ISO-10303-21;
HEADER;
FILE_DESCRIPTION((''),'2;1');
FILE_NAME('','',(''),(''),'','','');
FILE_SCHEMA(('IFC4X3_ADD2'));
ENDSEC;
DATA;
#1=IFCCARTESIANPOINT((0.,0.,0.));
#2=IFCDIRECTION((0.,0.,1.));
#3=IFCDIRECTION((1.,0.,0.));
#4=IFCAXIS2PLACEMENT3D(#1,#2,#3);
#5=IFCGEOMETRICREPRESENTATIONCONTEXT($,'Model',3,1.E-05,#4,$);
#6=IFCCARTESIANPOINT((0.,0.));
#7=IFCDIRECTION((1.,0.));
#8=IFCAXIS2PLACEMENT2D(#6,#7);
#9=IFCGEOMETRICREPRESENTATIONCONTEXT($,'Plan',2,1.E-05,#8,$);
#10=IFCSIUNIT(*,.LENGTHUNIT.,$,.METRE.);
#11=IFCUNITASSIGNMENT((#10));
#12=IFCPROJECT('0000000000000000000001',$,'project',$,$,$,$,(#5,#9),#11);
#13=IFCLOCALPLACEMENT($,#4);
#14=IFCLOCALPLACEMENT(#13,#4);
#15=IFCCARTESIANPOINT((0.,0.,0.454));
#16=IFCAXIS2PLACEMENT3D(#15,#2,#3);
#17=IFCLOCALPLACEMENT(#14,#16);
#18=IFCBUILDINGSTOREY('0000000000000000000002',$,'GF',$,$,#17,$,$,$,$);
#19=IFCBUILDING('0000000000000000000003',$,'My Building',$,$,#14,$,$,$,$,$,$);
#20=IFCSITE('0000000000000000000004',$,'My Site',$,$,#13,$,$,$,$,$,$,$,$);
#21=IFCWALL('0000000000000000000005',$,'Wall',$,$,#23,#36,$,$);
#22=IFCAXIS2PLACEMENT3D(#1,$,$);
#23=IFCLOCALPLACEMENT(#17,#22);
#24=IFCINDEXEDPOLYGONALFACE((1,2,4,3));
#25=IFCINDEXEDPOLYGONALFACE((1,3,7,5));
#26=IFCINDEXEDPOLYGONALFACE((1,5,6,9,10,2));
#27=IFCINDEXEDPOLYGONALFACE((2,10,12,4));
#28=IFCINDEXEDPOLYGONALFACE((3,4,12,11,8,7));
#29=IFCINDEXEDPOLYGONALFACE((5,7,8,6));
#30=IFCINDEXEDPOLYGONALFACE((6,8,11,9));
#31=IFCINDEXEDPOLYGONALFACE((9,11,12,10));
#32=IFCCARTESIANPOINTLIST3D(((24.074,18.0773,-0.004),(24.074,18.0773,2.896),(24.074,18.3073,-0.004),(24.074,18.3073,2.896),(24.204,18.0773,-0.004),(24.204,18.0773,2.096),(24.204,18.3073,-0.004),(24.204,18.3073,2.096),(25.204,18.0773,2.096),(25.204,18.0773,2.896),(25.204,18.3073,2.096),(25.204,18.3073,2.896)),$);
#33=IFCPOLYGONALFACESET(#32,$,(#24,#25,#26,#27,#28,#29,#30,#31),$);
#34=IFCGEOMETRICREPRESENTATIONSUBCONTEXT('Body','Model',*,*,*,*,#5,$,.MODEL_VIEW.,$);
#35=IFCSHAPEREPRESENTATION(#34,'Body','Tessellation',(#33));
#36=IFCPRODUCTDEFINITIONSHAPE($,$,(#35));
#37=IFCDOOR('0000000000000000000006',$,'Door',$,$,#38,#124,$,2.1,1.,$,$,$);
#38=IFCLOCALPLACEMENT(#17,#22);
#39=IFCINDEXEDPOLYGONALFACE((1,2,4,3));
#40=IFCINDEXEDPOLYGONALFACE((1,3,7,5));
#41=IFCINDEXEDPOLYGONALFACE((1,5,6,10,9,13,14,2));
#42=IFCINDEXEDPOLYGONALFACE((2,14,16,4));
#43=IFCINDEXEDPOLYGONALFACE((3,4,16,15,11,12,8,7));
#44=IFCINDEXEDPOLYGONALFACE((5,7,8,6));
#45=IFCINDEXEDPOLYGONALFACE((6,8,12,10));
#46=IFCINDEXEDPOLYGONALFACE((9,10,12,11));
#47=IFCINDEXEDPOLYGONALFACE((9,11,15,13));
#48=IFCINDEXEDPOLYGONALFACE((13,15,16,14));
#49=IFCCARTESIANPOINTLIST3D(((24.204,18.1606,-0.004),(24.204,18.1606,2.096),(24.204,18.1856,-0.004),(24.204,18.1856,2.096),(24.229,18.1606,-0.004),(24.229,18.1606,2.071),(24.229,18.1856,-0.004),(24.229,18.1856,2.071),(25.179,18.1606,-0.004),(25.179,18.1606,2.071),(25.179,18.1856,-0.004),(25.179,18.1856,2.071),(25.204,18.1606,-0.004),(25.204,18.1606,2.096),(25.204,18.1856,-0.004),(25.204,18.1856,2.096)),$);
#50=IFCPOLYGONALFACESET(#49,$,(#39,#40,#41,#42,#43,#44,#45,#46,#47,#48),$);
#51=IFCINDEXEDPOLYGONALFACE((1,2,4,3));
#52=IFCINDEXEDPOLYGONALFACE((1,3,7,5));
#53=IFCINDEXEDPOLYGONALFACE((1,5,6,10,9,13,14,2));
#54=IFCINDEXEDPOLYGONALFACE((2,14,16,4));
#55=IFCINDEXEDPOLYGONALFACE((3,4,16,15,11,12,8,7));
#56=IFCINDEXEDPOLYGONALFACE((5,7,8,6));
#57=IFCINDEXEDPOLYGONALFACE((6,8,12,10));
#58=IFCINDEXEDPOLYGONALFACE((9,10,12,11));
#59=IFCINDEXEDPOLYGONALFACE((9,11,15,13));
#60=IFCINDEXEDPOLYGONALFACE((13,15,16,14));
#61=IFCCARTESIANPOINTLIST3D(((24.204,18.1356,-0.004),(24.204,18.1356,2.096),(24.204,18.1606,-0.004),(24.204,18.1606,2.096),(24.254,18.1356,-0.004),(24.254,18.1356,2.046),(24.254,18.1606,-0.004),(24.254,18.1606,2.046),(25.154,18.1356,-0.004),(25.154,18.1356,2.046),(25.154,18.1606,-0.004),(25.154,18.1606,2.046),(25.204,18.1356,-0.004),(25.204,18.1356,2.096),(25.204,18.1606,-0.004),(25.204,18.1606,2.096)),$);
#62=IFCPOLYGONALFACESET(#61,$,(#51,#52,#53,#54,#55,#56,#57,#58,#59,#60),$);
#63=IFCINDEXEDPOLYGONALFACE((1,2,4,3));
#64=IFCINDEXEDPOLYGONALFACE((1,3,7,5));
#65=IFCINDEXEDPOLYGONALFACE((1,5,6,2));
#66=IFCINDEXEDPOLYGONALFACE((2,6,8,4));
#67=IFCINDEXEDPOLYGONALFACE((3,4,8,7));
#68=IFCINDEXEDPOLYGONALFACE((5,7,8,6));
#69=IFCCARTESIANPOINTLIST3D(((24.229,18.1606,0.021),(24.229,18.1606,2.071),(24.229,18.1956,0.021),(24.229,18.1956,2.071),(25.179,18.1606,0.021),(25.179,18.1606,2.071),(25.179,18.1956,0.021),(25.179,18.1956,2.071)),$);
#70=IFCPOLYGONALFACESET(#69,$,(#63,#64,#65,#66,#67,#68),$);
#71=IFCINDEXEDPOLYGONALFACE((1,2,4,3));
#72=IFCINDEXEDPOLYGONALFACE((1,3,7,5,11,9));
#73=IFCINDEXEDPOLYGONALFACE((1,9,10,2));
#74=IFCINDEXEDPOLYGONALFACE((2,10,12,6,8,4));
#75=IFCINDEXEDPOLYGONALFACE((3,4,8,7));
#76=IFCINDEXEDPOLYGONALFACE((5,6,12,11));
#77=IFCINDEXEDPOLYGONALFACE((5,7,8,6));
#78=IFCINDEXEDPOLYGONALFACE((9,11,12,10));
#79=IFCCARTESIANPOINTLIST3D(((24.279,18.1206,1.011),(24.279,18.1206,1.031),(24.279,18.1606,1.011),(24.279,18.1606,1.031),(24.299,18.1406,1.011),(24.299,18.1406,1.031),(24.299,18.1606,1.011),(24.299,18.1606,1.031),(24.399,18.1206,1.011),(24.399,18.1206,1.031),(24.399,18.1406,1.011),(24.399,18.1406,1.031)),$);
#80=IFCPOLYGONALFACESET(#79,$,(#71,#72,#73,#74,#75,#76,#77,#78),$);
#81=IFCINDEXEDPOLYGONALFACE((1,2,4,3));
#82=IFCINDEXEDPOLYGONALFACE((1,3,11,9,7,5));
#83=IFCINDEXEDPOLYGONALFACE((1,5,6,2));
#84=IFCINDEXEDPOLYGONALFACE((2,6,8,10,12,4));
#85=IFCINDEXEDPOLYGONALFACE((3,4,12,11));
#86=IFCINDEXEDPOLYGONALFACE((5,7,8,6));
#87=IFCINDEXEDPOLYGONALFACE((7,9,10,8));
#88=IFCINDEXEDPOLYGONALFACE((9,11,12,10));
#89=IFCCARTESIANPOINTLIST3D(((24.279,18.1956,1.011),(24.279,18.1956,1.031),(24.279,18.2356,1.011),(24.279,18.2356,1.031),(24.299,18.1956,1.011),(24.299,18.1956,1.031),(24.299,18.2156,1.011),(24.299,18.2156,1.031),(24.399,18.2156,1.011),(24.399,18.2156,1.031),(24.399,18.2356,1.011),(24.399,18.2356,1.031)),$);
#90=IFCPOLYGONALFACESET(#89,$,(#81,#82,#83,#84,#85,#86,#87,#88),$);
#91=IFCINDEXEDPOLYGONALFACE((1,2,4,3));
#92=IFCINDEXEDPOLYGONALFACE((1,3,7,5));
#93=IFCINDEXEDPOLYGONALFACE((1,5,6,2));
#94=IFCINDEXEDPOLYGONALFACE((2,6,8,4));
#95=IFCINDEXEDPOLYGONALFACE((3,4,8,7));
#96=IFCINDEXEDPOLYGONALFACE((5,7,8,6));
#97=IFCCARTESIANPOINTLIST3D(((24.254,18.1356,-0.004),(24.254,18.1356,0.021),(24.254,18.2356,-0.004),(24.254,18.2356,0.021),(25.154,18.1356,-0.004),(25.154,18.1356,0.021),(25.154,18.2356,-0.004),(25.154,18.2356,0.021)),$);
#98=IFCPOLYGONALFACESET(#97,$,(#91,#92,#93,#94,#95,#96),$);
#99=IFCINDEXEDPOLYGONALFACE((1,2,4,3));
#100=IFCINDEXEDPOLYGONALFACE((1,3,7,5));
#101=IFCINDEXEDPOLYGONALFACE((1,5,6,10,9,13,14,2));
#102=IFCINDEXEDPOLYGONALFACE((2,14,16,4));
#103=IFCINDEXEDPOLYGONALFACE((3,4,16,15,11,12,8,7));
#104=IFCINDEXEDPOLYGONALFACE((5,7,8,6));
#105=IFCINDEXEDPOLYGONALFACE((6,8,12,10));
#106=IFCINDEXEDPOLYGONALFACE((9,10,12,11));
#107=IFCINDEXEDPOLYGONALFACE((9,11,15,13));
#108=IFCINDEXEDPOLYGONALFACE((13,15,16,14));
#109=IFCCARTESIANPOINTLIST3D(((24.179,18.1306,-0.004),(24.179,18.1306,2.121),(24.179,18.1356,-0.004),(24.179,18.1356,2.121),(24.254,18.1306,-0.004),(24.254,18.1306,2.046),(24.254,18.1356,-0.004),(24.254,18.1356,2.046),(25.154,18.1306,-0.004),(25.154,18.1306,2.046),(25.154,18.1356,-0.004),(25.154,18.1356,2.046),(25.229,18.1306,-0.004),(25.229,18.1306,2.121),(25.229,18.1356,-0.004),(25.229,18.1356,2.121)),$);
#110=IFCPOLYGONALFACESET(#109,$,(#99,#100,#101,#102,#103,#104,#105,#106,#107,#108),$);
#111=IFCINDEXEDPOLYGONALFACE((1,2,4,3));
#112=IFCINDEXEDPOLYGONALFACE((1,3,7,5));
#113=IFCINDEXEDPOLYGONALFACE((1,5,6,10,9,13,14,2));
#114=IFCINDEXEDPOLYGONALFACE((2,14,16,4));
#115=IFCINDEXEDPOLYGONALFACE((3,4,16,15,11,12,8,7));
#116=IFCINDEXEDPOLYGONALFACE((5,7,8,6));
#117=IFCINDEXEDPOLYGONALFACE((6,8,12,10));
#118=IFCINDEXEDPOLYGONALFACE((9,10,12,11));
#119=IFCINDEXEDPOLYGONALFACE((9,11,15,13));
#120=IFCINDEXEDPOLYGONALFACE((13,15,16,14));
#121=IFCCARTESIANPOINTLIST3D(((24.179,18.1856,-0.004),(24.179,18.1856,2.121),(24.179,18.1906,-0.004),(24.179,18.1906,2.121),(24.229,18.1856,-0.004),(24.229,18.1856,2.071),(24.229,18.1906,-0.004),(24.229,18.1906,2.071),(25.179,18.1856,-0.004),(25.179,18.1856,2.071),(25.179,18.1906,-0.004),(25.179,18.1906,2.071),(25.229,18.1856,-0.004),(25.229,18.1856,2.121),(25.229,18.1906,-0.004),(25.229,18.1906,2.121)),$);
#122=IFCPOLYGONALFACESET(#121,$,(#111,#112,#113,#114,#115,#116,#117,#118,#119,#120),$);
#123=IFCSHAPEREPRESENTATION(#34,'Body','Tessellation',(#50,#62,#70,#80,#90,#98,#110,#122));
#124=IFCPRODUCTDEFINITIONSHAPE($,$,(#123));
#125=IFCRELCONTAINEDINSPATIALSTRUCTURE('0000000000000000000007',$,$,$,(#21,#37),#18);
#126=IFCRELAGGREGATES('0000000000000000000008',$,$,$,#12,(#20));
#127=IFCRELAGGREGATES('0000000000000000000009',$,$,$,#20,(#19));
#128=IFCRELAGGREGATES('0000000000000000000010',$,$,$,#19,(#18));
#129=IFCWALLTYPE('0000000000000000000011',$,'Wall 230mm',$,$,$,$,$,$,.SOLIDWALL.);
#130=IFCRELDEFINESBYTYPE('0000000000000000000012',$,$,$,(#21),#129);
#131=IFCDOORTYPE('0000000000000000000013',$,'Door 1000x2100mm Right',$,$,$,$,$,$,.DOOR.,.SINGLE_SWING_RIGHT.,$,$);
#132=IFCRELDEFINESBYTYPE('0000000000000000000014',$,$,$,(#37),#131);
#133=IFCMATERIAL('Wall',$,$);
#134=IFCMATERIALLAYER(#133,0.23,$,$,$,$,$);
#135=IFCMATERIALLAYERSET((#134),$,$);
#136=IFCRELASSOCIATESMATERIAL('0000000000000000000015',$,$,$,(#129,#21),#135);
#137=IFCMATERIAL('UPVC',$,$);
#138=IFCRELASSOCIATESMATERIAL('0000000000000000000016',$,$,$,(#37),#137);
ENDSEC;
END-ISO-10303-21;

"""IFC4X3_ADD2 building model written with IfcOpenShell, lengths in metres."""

from ifc_helpers import new_model, entity, si_unit, frame, origin_with_axes, origin_2d_with_axis, place, context, subcontext, project, spatial, line, indexed_curve, outline, extrude, shape, source, transform, mapped, material, layer, layer_set, layer_usage, type_object, type_shapes, element, fill, save


model = new_model("IFC4X3_ADD2")

# Units and contexts
model_context = context("Model", 3, precision=1e-05, world=origin_with_axes())
plan_context = context("Plan", 2, precision=1e-05, world=origin_2d_with_axis())
body_context_1 = subcontext(model_context, "Body", "Model", "MODEL_VIEW")
body_context_2 = subcontext(plan_context, "Body", "Plan", "PLAN_VIEW")
ifc_project = project(units=[si_unit("LENGTHUNIT", "METRE")], contexts=[model_context, plan_context])

# Site, building, storey
site_placement = place(None, origin_with_axes())
site = spatial("IfcSite", under=ifc_project, at=site_placement, Name="My Site")
building_placement = place(site_placement, origin_with_axes())
building = spatial("IfcBuilding", under=site, at=building_placement, Name="My Building")
storey_placement = place(building_placement, frame((0.0, 0.0, 0.454), z_axis=(0.0, 0.0, 1.0), x_axis=(1.0, 0.0, 0.0)))
storey = spatial("IfcBuildingStorey", under=building, at=storey_placement, Name="GF")

# Shared definitions
ifc_material_1 = material(Name="Wall")
ifc_layer = layer(ifc_material_1, 0.23)
ifc_layer_set = layer_set([ifc_layer])
wall_type = type_object("IfcWallType", Name="Wall 230mm", PredefinedType="SOLIDWALL", material=ifc_layer_set)

# Shared definitions
shared_shape_1 = source(origin_with_axes(), body_context_1, "Body", "SweptSolid", [
    extrude(outline(indexed_curve([(0.0, 0.0), (1.0, 0.0), (1.0, 2.1), (0.0, 2.1)], segments=[line(1, 2, 3, 4, 1)])), frame((0.0, -0.6, 0.0), z_axis=(0.0, -1.0, 0.0), x_axis=(1.0, 0.0, 0.0)), (0.0, 0.0, -1.0), 1.2),
])
ifc_material_2 = material(Name="UPVC")
door_type_1 = type_object("IfcDoorType", Name="Door 1000x2100mm Right", OperationType="SINGLE_SWING_RIGHT", PredefinedType="DOOR")
shared_shape_2 = source(origin_with_axes(), body_context_1, "Body", "SweptSolid", [
    extrude(outline(indexed_curve([(0.0, 0.0), (0.0, 2.1), (1.0, 2.1), (1.0, 0.0), (0.975, 0.0), (0.975, 2.075), (0.025, 2.075), (0.025, 0.0)], segments=[line(1, 2, 3, 4, 5, 6, 7, 8, 1)])), frame((0.0, 0.025, 0.0), z_axis=(0.0, -1.0, 0.0), x_axis=(1.0, 0.0, 0.0)), (0.0, 0.0, -1.0), 0.025),
    extrude(outline(indexed_curve([(0.0, 0.0), (0.0, 2.1), (1.0, 2.1), (1.0, 0.0), (0.95, 0.0), (0.95, 2.05), (0.05, 2.05), (0.05, 0.0)], segments=[line(1, 2, 3, 4, 5, 6, 7, 8, 1)])), frame((0.0, 0.0, 0.0), z_axis=(0.0, -1.0, 0.0), x_axis=(1.0, 0.0, 0.0)), (0.0, 0.0, -1.0), 0.025),
    extrude(outline(indexed_curve([(0.0, 0.0), (0.95, 0.0), (0.95, 0.035), (0.0, 0.035)], segments=[line(1, 2, 3, 4, 1)])), frame((0.025, 0.025, 0.025), z_axis=(0.0, 0.0, 1.0), x_axis=(1.0, 0.0, 0.0)), (0.0, 0.0, 1.0), 2.05),
    extrude(outline(indexed_curve([(0.0, 0.0), (0.0, -0.04), (0.12, -0.04), (0.12, -0.02), (0.02, -0.02), (0.02, 0.0)], segments=[line(1, 2, 3, 4, 5, 6, 1)])), frame((0.075, 0.025, 1.015), z_axis=(0.0, 0.0, 1.0), x_axis=(1.0, 0.0, 0.0)), (0.0, 0.0, 1.0), 0.02),
    extrude(outline(indexed_curve([(0.0, 0.0), (0.0, 0.04), (0.12, 0.04), (0.12, 0.02), (0.02, 0.02), (0.02, 0.0)], segments=[line(1, 2, 3, 4, 5, 6, 1)])), frame((0.075, 0.06, 1.015), z_axis=(0.0, 0.0, 1.0), x_axis=(1.0, 0.0, 0.0)), (0.0, 0.0, 1.0), 0.02),
    extrude(outline(indexed_curve([(0.0, 0.0), (0.9, 0.0), (0.9, 0.1), (0.0, 0.1)], segments=[line(1, 2, 3, 4, 1)])), frame((0.05, 0.0, 0.0), z_axis=(0.0, 0.0, 1.0), x_axis=(1.0, 0.0, 0.0)), (0.0, 0.0, 1.0), 0.025),
    extrude(outline(indexed_curve([(0.0, 0.0), (0.0, 2.125), (1.05, 2.125), (1.05, 0.0), (0.975, 0.0), (0.975, 2.05), (0.075, 2.05), (0.075, 0.0)], segments=[line(1, 2, 3, 4, 5, 6, 7, 8, 1)])), frame((-0.025, -0.005, 0.0), z_axis=(0.0, -1.0, 0.0), x_axis=(1.0, 0.0, 0.0)), (0.0, 0.0, -1.0), 0.005),
    extrude(outline(indexed_curve([(0.0, 0.0), (0.0, 2.125), (1.05, 2.125), (1.05, 0.0), (1.0, 0.0), (1.0, 2.075), (0.05, 2.075), (0.05, 0.0)], segments=[line(1, 2, 3, 4, 5, 6, 7, 8, 1)])), frame((-0.025, 0.05, 0.0), z_axis=(0.0, -1.0, 0.0), x_axis=(1.0, 0.0, 0.0)), (0.0, 0.0, -1.0), 0.005),
])
shared_shape_3 = source(origin_with_axes(), body_context_2, "Body", "Curve2D", [
    entity("IfcIndexedPolyCurve", entity("IfcCartesianPointList2D", [[0.0, 0.0], [0.0, 0.05], [0.025, 0.05], [0.025, 0.025], [0.05, 0.025], [0.05, 0.0]]), [entity("IfcLineIndex", [1, 2, 3, 4, 5, 6, 1])]),
    entity("IfcIndexedPolyCurve", entity("IfcCartesianPointList2D", [[1.0, 0.0], [1.0, 0.05], [0.975, 0.05], [0.975, 0.025], [0.95, 0.025], [0.95, 0.0]]), [entity("IfcLineIndex", [1, 2, 3, 4, 5, 6, 1])]),
    entity("IfcTrimmedCurve", entity("IfcEllipse", entity("IfcAxis2Placement2D", entity("IfcCartesianPoint", [0.94, 0.05]), entity("IfcDirection", [1.0, 0.0])), 0.915, 0.95), [entity("IfcCartesianPoint", [0.94, 1.0])], [entity("IfcCartesianPoint", [0.025, 0.05])], True, "CARTESIAN"),
    entity("IfcIndexedPolyCurve", entity("IfcCartesianPointList2D", [[0.975, 0.05], [0.94, 0.05], [0.94, 1.0], [0.975, 1.0]]), [entity("IfcLineIndex", [1, 2, 3, 4, 1])]),
])
type_shapes(door_type_1, [shared_shape_2, shared_shape_3])

# Wall, opening, door
ifc_layer_usage_1 = layer_usage(ifc_layer_set, "AXIS2", "POSITIVE", 0.0)
wall_1_placement = place(storey_placement, frame((25.204, 18.3073, -0.004), z_axis=(0.0, 0.0, 1.0), x_axis=(-1.0, 0.0, 0.0)))
wall_1 = element("IfcWall", 1, at=wall_1_placement, inside=storey, type_object=wall_type, material=ifc_layer_usage_1, Name="Wall", context=body_context_1, shape_type="SweptSolid", body=[
    extrude(outline(indexed_curve([(0.0, 0.0), (0.0, 0.23), (1.13, 0.23), (1.13, 0.0), (0.0, 0.0)], self_intersect=False)), origin_with_axes(), (0.0, 0.0, 1.0), 2.9),
])
opening_1_placement = place(wall_1_placement, frame((0.0, 0.0, 0.0), z_axis=(0.0, 0.0, 1.0), x_axis=(1.0, 0.0, 0.0)))
opening_1 = element("IfcOpeningElement", 2, at=opening_1_placement, cuts=wall_1, PredefinedType="OPENING", context=body_context_1, shape_type="MappedRepresentation", body=[
    mapped(shared_shape_1, transform((0.0, 0.0, 0.0), x_axis=(1.0, 0.0, 0.0), y_axis=(0.0, 1.0, 0.0), z_axis=(0.0, 0.0, 1.0), scale=1.0)),
])
door_1_placement = place(opening_1_placement, frame((1.0, 0.1717, 0.0), z_axis=(0.0, 0.0, 1.0), x_axis=(-1.0, 0.0, 0.0)))
door_1 = element("IfcDoor", 3, at=door_1_placement, inside=storey, type_object=door_type_1, material=ifc_material_2, Name="Door", OverallHeight=2.1, OverallWidth=1.0, shapes=[
    shape(body_context_1, "Body", "MappedRepresentation", [mapped(shared_shape_2, transform((0.0, 0.0, 0.0), x_axis=(1.0, 0.0, 0.0), y_axis=(0.0, 1.0, 0.0), z_axis=(0.0, 0.0, 1.0), scale=1.0))]),
    shape(body_context_2, "Body", "MappedRepresentation", [mapped(shared_shape_3, transform((0.0, 0.0, 0.0), x_axis=(1.0, 0.0, 0.0), y_axis=(0.0, 1.0, 0.0), z_axis=(0.0, 0.0, 1.0), scale=1.0))]),
])
fill(opening_1, door_1)

save(model, "model.ifc")
